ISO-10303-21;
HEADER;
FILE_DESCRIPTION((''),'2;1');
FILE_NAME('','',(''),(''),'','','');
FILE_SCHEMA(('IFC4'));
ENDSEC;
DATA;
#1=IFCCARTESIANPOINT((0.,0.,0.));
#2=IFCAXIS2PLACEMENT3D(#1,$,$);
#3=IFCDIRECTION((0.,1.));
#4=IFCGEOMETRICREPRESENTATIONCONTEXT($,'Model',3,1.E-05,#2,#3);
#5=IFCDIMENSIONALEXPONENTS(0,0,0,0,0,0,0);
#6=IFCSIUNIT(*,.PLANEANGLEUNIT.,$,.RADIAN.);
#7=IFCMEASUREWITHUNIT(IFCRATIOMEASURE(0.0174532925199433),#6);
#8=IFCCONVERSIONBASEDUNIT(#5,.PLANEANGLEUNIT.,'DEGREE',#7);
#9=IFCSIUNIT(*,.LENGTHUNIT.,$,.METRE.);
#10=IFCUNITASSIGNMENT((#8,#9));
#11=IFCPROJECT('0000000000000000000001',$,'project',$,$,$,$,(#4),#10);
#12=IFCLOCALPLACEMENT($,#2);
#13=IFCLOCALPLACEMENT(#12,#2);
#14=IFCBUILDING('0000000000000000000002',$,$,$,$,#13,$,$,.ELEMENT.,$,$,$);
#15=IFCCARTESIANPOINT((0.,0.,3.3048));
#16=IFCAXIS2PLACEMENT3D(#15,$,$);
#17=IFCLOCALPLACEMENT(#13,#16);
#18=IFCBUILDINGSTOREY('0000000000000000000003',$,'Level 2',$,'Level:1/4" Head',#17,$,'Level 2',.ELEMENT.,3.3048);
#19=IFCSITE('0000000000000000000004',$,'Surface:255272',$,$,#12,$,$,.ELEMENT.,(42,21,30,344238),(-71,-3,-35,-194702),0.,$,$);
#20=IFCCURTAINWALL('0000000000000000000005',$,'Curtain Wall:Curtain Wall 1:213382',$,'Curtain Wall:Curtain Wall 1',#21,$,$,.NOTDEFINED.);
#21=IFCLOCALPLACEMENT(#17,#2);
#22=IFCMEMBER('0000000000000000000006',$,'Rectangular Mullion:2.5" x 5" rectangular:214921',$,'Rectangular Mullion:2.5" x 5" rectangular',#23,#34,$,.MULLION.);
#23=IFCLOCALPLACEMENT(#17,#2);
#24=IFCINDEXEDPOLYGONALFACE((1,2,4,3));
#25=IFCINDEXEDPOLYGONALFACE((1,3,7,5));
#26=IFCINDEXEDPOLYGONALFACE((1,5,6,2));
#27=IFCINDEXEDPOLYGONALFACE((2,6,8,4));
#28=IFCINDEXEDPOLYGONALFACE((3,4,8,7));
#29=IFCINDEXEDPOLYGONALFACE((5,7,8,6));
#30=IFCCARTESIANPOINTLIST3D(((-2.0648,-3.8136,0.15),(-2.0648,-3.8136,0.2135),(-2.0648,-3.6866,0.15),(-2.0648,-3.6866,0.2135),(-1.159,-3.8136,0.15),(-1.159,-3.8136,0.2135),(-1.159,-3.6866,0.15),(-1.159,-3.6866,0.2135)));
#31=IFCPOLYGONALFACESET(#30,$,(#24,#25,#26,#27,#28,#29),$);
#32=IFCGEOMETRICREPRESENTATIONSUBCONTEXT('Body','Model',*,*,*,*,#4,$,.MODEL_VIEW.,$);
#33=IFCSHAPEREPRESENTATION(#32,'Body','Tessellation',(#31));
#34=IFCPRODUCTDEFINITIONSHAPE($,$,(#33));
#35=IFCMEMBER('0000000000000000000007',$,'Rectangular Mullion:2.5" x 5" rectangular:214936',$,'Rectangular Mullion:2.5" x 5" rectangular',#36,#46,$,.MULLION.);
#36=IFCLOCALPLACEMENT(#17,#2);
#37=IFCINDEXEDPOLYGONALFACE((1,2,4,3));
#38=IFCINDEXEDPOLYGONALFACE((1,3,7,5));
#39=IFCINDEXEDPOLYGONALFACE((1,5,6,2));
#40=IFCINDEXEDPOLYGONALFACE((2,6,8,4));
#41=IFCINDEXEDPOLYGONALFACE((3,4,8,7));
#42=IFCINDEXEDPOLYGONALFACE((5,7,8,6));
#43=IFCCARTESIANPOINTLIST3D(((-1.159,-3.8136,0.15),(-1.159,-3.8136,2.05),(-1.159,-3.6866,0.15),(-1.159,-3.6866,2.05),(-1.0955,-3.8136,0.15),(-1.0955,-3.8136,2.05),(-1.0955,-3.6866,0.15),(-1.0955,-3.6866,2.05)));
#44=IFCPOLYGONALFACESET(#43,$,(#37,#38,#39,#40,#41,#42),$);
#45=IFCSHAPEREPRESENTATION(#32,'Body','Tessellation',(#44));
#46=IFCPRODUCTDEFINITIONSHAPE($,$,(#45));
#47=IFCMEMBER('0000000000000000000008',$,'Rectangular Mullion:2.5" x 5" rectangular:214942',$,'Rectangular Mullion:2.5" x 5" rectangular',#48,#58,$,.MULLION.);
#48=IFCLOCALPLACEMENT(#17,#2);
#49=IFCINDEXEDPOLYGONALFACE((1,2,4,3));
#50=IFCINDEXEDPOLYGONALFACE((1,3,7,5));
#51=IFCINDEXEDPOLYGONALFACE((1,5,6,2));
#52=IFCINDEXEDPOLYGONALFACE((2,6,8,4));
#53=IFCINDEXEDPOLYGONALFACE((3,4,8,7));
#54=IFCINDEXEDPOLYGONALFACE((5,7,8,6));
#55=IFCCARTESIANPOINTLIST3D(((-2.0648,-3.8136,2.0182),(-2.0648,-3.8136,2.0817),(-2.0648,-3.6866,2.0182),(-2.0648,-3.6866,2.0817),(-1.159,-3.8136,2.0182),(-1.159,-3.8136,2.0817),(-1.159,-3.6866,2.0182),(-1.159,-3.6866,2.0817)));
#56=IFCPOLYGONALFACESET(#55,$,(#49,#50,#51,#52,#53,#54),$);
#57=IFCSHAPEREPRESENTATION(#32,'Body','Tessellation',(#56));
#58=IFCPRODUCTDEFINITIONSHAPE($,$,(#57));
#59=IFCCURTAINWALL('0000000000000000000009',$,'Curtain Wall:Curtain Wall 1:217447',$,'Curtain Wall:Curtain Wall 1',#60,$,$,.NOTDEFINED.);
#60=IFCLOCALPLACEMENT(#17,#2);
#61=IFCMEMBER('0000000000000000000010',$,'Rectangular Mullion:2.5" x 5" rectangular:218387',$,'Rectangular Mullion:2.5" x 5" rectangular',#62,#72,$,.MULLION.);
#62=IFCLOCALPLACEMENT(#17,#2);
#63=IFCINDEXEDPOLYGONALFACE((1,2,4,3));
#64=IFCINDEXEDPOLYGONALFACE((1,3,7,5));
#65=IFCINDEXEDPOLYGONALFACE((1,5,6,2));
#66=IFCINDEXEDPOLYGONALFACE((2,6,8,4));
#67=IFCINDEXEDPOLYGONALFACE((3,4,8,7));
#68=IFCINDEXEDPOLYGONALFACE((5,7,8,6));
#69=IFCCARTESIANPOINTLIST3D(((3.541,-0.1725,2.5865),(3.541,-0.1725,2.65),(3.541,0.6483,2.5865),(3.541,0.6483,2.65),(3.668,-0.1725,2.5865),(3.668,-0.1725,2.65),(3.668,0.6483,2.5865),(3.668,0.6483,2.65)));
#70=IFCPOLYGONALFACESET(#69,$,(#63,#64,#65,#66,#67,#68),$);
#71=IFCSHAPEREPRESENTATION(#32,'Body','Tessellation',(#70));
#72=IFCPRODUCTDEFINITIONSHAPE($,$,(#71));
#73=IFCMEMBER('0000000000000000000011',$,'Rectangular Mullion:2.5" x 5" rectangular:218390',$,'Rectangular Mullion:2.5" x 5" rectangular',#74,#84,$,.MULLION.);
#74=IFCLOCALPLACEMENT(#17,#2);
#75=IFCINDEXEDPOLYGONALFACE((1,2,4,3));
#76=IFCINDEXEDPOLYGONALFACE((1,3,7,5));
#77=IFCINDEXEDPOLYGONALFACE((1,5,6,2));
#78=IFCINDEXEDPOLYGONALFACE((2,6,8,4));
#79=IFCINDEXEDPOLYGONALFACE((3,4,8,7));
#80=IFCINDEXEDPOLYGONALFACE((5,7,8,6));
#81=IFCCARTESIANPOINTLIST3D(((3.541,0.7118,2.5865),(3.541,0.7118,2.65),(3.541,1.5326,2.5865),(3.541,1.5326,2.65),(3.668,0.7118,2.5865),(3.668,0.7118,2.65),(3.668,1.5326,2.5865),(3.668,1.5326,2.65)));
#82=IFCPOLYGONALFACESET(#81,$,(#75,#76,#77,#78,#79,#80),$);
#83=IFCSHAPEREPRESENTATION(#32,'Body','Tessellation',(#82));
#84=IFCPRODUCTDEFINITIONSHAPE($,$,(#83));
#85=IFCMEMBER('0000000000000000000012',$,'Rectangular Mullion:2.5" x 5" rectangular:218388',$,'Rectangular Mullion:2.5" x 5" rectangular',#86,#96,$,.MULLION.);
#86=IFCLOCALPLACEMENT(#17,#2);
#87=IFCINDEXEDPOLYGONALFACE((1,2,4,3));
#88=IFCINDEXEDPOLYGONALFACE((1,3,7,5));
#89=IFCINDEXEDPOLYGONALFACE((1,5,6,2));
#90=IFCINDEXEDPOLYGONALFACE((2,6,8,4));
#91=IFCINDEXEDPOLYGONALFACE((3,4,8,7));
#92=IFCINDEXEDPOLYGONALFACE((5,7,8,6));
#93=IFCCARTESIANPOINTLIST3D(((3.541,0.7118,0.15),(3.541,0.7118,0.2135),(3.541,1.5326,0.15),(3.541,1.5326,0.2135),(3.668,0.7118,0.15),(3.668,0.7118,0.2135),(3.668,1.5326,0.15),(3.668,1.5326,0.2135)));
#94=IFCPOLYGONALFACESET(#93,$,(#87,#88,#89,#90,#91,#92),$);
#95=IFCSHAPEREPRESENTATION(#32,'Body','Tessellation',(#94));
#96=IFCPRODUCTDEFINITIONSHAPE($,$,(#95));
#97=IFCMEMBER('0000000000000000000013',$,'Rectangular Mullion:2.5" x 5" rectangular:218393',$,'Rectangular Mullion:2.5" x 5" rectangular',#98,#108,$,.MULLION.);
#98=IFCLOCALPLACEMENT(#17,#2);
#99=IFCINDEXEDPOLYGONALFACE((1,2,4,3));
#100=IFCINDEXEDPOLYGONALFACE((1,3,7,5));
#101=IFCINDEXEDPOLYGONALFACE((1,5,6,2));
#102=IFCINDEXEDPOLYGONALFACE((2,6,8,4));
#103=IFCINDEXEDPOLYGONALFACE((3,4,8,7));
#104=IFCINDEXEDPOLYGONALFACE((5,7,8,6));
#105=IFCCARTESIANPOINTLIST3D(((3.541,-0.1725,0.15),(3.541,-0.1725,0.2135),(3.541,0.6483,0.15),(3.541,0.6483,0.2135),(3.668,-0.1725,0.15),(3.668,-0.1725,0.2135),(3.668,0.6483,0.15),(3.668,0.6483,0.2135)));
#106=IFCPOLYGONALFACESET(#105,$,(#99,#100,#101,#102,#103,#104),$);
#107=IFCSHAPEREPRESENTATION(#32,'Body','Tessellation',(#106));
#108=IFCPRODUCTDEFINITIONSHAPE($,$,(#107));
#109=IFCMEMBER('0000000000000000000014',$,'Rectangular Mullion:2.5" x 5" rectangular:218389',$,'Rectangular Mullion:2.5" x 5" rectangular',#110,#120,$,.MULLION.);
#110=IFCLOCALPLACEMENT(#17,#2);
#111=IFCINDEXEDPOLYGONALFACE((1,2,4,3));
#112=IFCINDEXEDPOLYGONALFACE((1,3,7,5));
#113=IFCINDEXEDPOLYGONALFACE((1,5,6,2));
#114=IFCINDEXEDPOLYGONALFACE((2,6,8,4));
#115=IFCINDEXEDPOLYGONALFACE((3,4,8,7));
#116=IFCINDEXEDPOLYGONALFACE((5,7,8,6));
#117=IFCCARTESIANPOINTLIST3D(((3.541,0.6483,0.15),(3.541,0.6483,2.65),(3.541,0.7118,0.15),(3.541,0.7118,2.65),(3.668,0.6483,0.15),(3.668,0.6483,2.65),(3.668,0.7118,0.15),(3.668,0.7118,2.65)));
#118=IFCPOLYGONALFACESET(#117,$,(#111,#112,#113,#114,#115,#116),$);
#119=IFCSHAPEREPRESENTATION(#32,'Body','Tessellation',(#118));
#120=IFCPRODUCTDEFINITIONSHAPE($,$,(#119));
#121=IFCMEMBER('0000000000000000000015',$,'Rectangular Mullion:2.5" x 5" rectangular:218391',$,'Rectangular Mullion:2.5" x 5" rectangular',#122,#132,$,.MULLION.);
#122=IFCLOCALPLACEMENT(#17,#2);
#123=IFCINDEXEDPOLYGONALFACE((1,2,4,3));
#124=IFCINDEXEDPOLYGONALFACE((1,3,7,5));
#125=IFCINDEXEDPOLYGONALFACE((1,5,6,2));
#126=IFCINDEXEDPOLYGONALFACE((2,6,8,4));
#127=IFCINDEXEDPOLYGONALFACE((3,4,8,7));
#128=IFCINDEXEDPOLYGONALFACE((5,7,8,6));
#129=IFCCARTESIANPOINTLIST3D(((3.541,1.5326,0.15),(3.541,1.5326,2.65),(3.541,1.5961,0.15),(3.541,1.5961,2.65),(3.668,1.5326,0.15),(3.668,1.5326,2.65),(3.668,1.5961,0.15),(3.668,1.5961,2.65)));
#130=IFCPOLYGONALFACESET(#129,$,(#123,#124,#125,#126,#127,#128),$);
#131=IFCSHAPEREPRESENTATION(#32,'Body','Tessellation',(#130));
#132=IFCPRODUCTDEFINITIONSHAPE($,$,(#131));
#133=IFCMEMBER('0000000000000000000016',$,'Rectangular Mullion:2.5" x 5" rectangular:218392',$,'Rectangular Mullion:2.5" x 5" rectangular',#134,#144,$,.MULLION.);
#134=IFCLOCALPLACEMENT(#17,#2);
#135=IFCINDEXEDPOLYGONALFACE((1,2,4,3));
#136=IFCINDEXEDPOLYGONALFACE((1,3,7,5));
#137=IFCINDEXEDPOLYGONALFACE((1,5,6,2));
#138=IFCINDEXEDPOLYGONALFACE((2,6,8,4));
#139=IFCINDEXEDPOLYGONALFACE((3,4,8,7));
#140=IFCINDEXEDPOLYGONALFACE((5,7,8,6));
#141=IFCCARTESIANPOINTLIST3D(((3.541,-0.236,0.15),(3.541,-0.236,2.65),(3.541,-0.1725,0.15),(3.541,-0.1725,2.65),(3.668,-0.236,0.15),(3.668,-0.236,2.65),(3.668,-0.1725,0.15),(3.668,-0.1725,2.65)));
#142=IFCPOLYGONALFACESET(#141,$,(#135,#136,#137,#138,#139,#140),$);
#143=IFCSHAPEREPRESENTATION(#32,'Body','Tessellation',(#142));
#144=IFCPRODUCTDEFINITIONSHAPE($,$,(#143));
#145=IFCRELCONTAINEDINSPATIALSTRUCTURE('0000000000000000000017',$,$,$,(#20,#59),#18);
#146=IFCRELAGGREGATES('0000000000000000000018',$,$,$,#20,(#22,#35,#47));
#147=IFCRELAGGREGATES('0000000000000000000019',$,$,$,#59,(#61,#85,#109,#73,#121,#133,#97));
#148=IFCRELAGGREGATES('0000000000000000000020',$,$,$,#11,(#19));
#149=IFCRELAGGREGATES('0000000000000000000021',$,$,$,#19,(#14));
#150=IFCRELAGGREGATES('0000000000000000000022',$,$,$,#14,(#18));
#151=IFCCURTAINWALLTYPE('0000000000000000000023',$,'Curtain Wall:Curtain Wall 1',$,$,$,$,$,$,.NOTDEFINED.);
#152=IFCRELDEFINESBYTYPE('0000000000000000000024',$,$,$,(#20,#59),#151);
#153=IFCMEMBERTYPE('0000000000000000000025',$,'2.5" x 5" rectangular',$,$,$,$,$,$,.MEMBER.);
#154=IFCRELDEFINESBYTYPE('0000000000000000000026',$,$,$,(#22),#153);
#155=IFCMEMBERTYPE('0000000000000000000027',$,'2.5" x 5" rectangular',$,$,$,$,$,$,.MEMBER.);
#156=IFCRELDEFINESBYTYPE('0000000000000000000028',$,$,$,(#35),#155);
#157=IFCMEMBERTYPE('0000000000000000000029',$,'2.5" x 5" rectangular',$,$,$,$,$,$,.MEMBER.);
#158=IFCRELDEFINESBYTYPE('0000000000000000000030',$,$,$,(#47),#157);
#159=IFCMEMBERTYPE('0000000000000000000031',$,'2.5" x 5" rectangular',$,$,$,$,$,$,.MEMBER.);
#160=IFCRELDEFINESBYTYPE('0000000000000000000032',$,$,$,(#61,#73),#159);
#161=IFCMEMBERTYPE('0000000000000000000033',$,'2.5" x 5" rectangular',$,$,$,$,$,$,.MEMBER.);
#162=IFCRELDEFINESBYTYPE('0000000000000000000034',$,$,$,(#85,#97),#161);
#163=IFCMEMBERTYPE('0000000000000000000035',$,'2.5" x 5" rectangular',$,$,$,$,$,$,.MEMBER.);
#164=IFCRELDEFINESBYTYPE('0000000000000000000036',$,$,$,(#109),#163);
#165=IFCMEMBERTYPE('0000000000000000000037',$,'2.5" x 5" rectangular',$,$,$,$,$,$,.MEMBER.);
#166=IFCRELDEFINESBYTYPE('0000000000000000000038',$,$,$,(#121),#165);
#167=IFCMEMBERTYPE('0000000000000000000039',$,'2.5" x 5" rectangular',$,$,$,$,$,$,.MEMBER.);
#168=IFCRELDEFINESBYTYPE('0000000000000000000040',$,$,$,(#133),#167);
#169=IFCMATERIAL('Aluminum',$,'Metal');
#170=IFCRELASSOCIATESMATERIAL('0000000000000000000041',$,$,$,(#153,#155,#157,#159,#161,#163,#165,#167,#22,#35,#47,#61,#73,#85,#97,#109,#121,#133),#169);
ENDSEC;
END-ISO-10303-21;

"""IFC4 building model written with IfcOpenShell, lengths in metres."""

from ifc_helpers import new_model, entity, si_unit, converted_unit, direction, frame, origin, origin_2d_with_axis, place, context, subcontext, project, spatial, rectangle, extrude, source, transform, mapped, material, material_profile, profile_set, profile_usage, type_object, type_shapes, element, aggregate, save


model = new_model("IFC4")

# Units and contexts
model_context = context("Model", 3, precision=1e-05, world=origin(), true_north=direction((0.0, 1.0)))
body_context = subcontext(model_context, "Body", "Model", "MODEL_VIEW")
ifc_project = project(units=[converted_unit("PLANEANGLEUNIT", "DEGREE", entity("IfcRatioMeasure", 0.0174532925199433), si_unit("PLANEANGLEUNIT", "RADIAN"), dimensions=[0, 0, 0, 0, 0, 0, 0]), si_unit("LENGTHUNIT", "METRE")], contexts=[model_context])

# Site, building, storey
site_placement = place(None, origin())
site = spatial("IfcSite", under=ifc_project, at=site_placement, Name="Surface:255272", CompositionType="ELEMENT", RefLatitude=(42, 21, 30, 344238), RefLongitude=(-71, -3, -35, -194702), RefElevation=0.0)
building_placement = place(site_placement, origin())
building = spatial("IfcBuilding", under=site, at=building_placement, CompositionType="ELEMENT")
storey_placement = place(building_placement, frame((0.0, 0.0, 3.3048)))
storey = spatial("IfcBuildingStorey", under=building, at=storey_placement, Name="Level 2", ObjectType="Level:1/4\" Head", LongName="Level 2", CompositionType="ELEMENT", Elevation=3.3048)

# Curtain walls, members
curtain_wall_type = type_object("IfcCurtainWallType", Name="Curtain Wall:Curtain Wall 1", PredefinedType="NOTDEFINED")
curtain_wall_1_placement = place(storey_placement, frame((0.0, 0.0, -3.3048)))
curtain_wall_1 = element("IfcCurtainWall", 1, at=curtain_wall_1_placement, inside=storey, type_object=curtain_wall_type, Name="Curtain Wall:Curtain Wall 1:213382", ObjectType="Curtain Wall:Curtain Wall 1", PredefinedType="NOTDEFINED")
ifc_material_1 = material(Name="Aluminum", Category="Metal")
ifc_material_profile = material_profile(ifc_material_1, rectangle(XDim=0.127, YDim=0.0635, at=origin_2d_with_axis()), Name="2.5\" x 5\" rectangular")
ifc_profile_set = profile_set([ifc_material_profile], Name="2.5\" x 5\" rectangular")
ifc_profile_usage_1 = profile_usage(ifc_profile_set)
member_type_1 = type_object("IfcMemberType", Name="2.5\" x 5\" rectangular", PredefinedType="MEMBER", material=ifc_profile_set)
shared_shape_1 = source(origin(), body_context, "Body", "SweptSolid", [
    extrude(rectangle(XDim=0.127, YDim=0.0635, at=origin_2d_with_axis()), frame((-0.0318, 0.0, -0.9058), z_axis=(0.0, 0.0, 1.0), x_axis=(0.0, -1.0, 0.0)), (0.0, 0.0, 1.0), 0.9058),
])
type_shapes(member_type_1, [shared_shape_1])
member_1_placement = place(storey_placement, frame((-1.159, -3.7501, 0.15), z_axis=(1.0, -0.000007, 0.0), x_axis=(0.0, 0.0, -1.0)))
member_1 = element("IfcMember", 2, at=member_1_placement, type_object=member_type_1, material=ifc_profile_usage_1, Name="Rectangular Mullion:2.5\" x 5\" rectangular:214921", ObjectType="Rectangular Mullion:2.5\" x 5\" rectangular", PredefinedType="MULLION", context=body_context, shape_type="MappedRepresentation", body=[
    mapped(shared_shape_1, transform((0.0, 0.0, 0.0), scale=1.0)),
])
ifc_profile_usage_2 = profile_usage(ifc_profile_set)
member_type_2 = type_object("IfcMemberType", Name="2.5\" x 5\" rectangular", PredefinedType="MEMBER", material=ifc_profile_set)
shared_shape_2 = source(origin(), body_context, "Body", "SweptSolid", [
    extrude(rectangle(XDim=0.127, YDim=0.0635, at=origin_2d_with_axis()), frame((-0.0318, 0.0, -1.9), z_axis=(0.0, 0.0, 1.0), x_axis=(0.0, -1.0, 0.0)), (0.0, 0.0, 1.0), 1.9),
])
type_shapes(member_type_2, [shared_shape_2])
member_2_placement = place(storey_placement, frame((-1.0955, -3.7501, 2.05)))
member_2 = element("IfcMember", 3, at=member_2_placement, type_object=member_type_2, material=ifc_profile_usage_2, Name="Rectangular Mullion:2.5\" x 5\" rectangular:214936", ObjectType="Rectangular Mullion:2.5\" x 5\" rectangular", PredefinedType="MULLION", context=body_context, shape_type="MappedRepresentation", body=[
    mapped(shared_shape_2, transform((0.0, 0.0, 0.0), scale=1.0)),
])
ifc_profile_usage_3 = profile_usage(ifc_profile_set)
member_type_3 = type_object("IfcMemberType", Name="2.5\" x 5\" rectangular", PredefinedType="MEMBER", material=ifc_profile_set)
shared_shape_3 = source(origin(), body_context, "Body", "SweptSolid", [
    extrude(rectangle(XDim=0.127, YDim=0.0635, at=origin_2d_with_axis()), frame((0.0, 0.0, -0.9058), z_axis=(0.0, 0.0, 1.0), x_axis=(0.0, -1.0, 0.0)), (0.0, 0.0, 1.0), 0.9058),
])
type_shapes(member_type_3, [shared_shape_3])
member_3_placement = place(storey_placement, frame((-2.0648, -3.7501, 2.05), z_axis=(-1.0, 0.000007, 0.0), x_axis=(0.0, 0.0, 1.0)))
member_3 = element("IfcMember", 4, at=member_3_placement, type_object=member_type_3, material=ifc_profile_usage_3, Name="Rectangular Mullion:2.5\" x 5\" rectangular:214942", ObjectType="Rectangular Mullion:2.5\" x 5\" rectangular", PredefinedType="MULLION", context=body_context, shape_type="MappedRepresentation", body=[
    mapped(shared_shape_3, transform((0.0, 0.0, 0.0), scale=1.0)),
])
curtain_wall_2_placement = place(storey_placement, frame((0.0, 0.0, -3.3048)))
curtain_wall_2 = element("IfcCurtainWall", 5, at=curtain_wall_2_placement, inside=storey, type_object=curtain_wall_type, Name="Curtain Wall:Curtain Wall 1:217447", ObjectType="Curtain Wall:Curtain Wall 1", PredefinedType="NOTDEFINED")
ifc_profile_usage_4 = profile_usage(ifc_profile_set)
member_type_4 = type_object("IfcMemberType", Name="2.5\" x 5\" rectangular", PredefinedType="MEMBER", material=ifc_profile_set)
shared_shape_4 = source(origin(), body_context, "Body", "SweptSolid", [
    extrude(rectangle(XDim=0.127, YDim=0.0635, at=origin_2d_with_axis()), frame((-0.0318, 0.0, -0.8208), z_axis=(0.0, 0.0, 1.0), x_axis=(0.0, -1.0, 0.0)), (0.0, 0.0, 1.0), 0.8208),
])
type_shapes(member_type_4, [shared_shape_4])
member_4_placement = place(storey_placement, frame((3.6045, 0.6483, 2.65), z_axis=(0.000007, 1.0, 0.0), x_axis=(0.0, 0.0, 1.0)))
member_4 = element("IfcMember", 6, at=member_4_placement, type_object=member_type_4, material=ifc_profile_usage_4, Name="Rectangular Mullion:2.5\" x 5\" rectangular:218387", ObjectType="Rectangular Mullion:2.5\" x 5\" rectangular", PredefinedType="MULLION", context=body_context, shape_type="MappedRepresentation", body=[
    mapped(shared_shape_4, transform((0.0, 0.0, 0.0), scale=1.0)),
])
ifc_profile_usage_5 = profile_usage(ifc_profile_set)
member_5_placement = place(storey_placement, frame((3.6045, 1.5326, 2.65), z_axis=(0.000007, 1.0, 0.0), x_axis=(0.0, 0.0, 1.0)))
member_5 = element("IfcMember", 7, at=member_5_placement, type_object=member_type_4, material=ifc_profile_usage_5, Name="Rectangular Mullion:2.5\" x 5\" rectangular:218390", ObjectType="Rectangular Mullion:2.5\" x 5\" rectangular", PredefinedType="MULLION", context=body_context, shape_type="MappedRepresentation", body=[
    mapped(shared_shape_4, transform((0.0, 0.0, 0.0), scale=1.0)),
])
ifc_profile_usage_6 = profile_usage(ifc_profile_set)
member_type_5 = type_object("IfcMemberType", Name="2.5\" x 5\" rectangular", PredefinedType="MEMBER", material=ifc_profile_set)
shared_shape_5 = source(origin(), body_context, "Body", "SweptSolid", [
    extrude(rectangle(XDim=0.127, YDim=0.0635, at=origin_2d_with_axis()), frame((-0.0318, 0.0, -0.8208), z_axis=(0.0, 0.0, 1.0), x_axis=(0.0, -1.0, 0.0)), (0.0, 0.0, 1.0), 0.8208),
])
type_shapes(member_type_5, [shared_shape_5])
member_6_placement = place(storey_placement, frame((3.6045, 0.7118, 0.15), z_axis=(-0.000007, -1.0, 0.0), x_axis=(0.0, 0.0, -1.0)))
member_6 = element("IfcMember", 8, at=member_6_placement, type_object=member_type_5, material=ifc_profile_usage_6, Name="Rectangular Mullion:2.5\" x 5\" rectangular:218388", ObjectType="Rectangular Mullion:2.5\" x 5\" rectangular", PredefinedType="MULLION", context=body_context, shape_type="MappedRepresentation", body=[
    mapped(shared_shape_5, transform((0.0, 0.0, 0.0), scale=1.0)),
])
ifc_profile_usage_7 = profile_usage(ifc_profile_set)
member_7_placement = place(storey_placement, frame((3.6045, -0.1725, 0.15), z_axis=(-0.000007, -1.0, 0.0), x_axis=(0.0, 0.0, -1.0)))
member_7 = element("IfcMember", 9, at=member_7_placement, type_object=member_type_5, material=ifc_profile_usage_7, Name="Rectangular Mullion:2.5\" x 5\" rectangular:218393", ObjectType="Rectangular Mullion:2.5\" x 5\" rectangular", PredefinedType="MULLION", context=body_context, shape_type="MappedRepresentation", body=[
    mapped(shared_shape_5, transform((0.0, 0.0, 0.0), scale=1.0)),
])
ifc_profile_usage_8 = profile_usage(ifc_profile_set)
member_type_6 = type_object("IfcMemberType", Name="2.5\" x 5\" rectangular", PredefinedType="MEMBER", material=ifc_profile_set)
shared_shape_6 = source(origin(), body_context, "Body", "SweptSolid", [
    extrude(rectangle(XDim=0.127, YDim=0.0635, at=origin_2d_with_axis()), frame((0.0, 0.0, -2.5), z_axis=(0.0, 0.0, 1.0), x_axis=(0.0, -1.0, 0.0)), (0.0, 0.0, 1.0), 2.5),
])
type_shapes(member_type_6, [shared_shape_6])
member_8_placement = place(storey_placement, frame((3.6045, 0.68, 0.15), z_axis=(0.0, 0.0, -1.0), x_axis=(0.000007, 1.0, 0.0)))
member_8 = element("IfcMember", 10, at=member_8_placement, type_object=member_type_6, material=ifc_profile_usage_8, Name="Rectangular Mullion:2.5\" x 5\" rectangular:218389", ObjectType="Rectangular Mullion:2.5\" x 5\" rectangular", PredefinedType="MULLION", context=body_context, shape_type="MappedRepresentation", body=[
    mapped(shared_shape_6, transform((0.0, 0.0, 0.0), scale=1.0)),
])
ifc_profile_usage_9 = profile_usage(ifc_profile_set)
member_type_7 = type_object("IfcMemberType", Name="2.5\" x 5\" rectangular", PredefinedType="MEMBER", material=ifc_profile_set)
shared_shape_7 = source(origin(), body_context, "Body", "SweptSolid", [
    extrude(rectangle(XDim=0.127, YDim=0.0635, at=origin_2d_with_axis()), frame((-0.0318, 0.0, -2.5), z_axis=(0.0, 0.0, 1.0), x_axis=(0.0, -1.0, 0.0)), (0.0, 0.0, 1.0), 2.5),
])
type_shapes(member_type_7, [shared_shape_7])
member_9_placement = place(storey_placement, frame((3.6045, 1.5961, 0.15), z_axis=(0.0, 0.0, -1.0), x_axis=(0.000007, 1.0, 0.0)))
member_9 = element("IfcMember", 11, at=member_9_placement, type_object=member_type_7, material=ifc_profile_usage_9, Name="Rectangular Mullion:2.5\" x 5\" rectangular:218391", ObjectType="Rectangular Mullion:2.5\" x 5\" rectangular", PredefinedType="MULLION", context=body_context, shape_type="MappedRepresentation", body=[
    mapped(shared_shape_7, transform((0.0, 0.0, 0.0), scale=1.0)),
])
ifc_profile_usage_10 = profile_usage(ifc_profile_set)
member_type_8 = type_object("IfcMemberType", Name="2.5\" x 5\" rectangular", PredefinedType="MEMBER", material=ifc_profile_set)
shared_shape_8 = source(origin(), body_context, "Body", "SweptSolid", [
    extrude(rectangle(XDim=0.127, YDim=0.0635, at=origin_2d_with_axis()), frame((-0.0318, 0.0, -2.5), z_axis=(0.0, 0.0, 1.0), x_axis=(0.0, -1.0, 0.0)), (0.0, 0.0, 1.0), 2.5),
])
type_shapes(member_type_8, [shared_shape_8])
member_10_placement = place(storey_placement, frame((3.6045, -0.236, 2.65), z_axis=(0.0, 0.0, 1.0), x_axis=(-0.000007, -1.0, 0.0)))
member_10 = element("IfcMember", 12, at=member_10_placement, type_object=member_type_8, material=ifc_profile_usage_10, Name="Rectangular Mullion:2.5\" x 5\" rectangular:218392", ObjectType="Rectangular Mullion:2.5\" x 5\" rectangular", PredefinedType="MULLION", context=body_context, shape_type="MappedRepresentation", body=[
    mapped(shared_shape_8, transform((0.0, 0.0, 0.0), scale=1.0)),
])

aggregate(curtain_wall_1, [member_1, member_2, member_3])

aggregate(curtain_wall_2, [member_4, member_6, member_8, member_5, member_9, member_10, member_7])

save(model, "model.ifc")
